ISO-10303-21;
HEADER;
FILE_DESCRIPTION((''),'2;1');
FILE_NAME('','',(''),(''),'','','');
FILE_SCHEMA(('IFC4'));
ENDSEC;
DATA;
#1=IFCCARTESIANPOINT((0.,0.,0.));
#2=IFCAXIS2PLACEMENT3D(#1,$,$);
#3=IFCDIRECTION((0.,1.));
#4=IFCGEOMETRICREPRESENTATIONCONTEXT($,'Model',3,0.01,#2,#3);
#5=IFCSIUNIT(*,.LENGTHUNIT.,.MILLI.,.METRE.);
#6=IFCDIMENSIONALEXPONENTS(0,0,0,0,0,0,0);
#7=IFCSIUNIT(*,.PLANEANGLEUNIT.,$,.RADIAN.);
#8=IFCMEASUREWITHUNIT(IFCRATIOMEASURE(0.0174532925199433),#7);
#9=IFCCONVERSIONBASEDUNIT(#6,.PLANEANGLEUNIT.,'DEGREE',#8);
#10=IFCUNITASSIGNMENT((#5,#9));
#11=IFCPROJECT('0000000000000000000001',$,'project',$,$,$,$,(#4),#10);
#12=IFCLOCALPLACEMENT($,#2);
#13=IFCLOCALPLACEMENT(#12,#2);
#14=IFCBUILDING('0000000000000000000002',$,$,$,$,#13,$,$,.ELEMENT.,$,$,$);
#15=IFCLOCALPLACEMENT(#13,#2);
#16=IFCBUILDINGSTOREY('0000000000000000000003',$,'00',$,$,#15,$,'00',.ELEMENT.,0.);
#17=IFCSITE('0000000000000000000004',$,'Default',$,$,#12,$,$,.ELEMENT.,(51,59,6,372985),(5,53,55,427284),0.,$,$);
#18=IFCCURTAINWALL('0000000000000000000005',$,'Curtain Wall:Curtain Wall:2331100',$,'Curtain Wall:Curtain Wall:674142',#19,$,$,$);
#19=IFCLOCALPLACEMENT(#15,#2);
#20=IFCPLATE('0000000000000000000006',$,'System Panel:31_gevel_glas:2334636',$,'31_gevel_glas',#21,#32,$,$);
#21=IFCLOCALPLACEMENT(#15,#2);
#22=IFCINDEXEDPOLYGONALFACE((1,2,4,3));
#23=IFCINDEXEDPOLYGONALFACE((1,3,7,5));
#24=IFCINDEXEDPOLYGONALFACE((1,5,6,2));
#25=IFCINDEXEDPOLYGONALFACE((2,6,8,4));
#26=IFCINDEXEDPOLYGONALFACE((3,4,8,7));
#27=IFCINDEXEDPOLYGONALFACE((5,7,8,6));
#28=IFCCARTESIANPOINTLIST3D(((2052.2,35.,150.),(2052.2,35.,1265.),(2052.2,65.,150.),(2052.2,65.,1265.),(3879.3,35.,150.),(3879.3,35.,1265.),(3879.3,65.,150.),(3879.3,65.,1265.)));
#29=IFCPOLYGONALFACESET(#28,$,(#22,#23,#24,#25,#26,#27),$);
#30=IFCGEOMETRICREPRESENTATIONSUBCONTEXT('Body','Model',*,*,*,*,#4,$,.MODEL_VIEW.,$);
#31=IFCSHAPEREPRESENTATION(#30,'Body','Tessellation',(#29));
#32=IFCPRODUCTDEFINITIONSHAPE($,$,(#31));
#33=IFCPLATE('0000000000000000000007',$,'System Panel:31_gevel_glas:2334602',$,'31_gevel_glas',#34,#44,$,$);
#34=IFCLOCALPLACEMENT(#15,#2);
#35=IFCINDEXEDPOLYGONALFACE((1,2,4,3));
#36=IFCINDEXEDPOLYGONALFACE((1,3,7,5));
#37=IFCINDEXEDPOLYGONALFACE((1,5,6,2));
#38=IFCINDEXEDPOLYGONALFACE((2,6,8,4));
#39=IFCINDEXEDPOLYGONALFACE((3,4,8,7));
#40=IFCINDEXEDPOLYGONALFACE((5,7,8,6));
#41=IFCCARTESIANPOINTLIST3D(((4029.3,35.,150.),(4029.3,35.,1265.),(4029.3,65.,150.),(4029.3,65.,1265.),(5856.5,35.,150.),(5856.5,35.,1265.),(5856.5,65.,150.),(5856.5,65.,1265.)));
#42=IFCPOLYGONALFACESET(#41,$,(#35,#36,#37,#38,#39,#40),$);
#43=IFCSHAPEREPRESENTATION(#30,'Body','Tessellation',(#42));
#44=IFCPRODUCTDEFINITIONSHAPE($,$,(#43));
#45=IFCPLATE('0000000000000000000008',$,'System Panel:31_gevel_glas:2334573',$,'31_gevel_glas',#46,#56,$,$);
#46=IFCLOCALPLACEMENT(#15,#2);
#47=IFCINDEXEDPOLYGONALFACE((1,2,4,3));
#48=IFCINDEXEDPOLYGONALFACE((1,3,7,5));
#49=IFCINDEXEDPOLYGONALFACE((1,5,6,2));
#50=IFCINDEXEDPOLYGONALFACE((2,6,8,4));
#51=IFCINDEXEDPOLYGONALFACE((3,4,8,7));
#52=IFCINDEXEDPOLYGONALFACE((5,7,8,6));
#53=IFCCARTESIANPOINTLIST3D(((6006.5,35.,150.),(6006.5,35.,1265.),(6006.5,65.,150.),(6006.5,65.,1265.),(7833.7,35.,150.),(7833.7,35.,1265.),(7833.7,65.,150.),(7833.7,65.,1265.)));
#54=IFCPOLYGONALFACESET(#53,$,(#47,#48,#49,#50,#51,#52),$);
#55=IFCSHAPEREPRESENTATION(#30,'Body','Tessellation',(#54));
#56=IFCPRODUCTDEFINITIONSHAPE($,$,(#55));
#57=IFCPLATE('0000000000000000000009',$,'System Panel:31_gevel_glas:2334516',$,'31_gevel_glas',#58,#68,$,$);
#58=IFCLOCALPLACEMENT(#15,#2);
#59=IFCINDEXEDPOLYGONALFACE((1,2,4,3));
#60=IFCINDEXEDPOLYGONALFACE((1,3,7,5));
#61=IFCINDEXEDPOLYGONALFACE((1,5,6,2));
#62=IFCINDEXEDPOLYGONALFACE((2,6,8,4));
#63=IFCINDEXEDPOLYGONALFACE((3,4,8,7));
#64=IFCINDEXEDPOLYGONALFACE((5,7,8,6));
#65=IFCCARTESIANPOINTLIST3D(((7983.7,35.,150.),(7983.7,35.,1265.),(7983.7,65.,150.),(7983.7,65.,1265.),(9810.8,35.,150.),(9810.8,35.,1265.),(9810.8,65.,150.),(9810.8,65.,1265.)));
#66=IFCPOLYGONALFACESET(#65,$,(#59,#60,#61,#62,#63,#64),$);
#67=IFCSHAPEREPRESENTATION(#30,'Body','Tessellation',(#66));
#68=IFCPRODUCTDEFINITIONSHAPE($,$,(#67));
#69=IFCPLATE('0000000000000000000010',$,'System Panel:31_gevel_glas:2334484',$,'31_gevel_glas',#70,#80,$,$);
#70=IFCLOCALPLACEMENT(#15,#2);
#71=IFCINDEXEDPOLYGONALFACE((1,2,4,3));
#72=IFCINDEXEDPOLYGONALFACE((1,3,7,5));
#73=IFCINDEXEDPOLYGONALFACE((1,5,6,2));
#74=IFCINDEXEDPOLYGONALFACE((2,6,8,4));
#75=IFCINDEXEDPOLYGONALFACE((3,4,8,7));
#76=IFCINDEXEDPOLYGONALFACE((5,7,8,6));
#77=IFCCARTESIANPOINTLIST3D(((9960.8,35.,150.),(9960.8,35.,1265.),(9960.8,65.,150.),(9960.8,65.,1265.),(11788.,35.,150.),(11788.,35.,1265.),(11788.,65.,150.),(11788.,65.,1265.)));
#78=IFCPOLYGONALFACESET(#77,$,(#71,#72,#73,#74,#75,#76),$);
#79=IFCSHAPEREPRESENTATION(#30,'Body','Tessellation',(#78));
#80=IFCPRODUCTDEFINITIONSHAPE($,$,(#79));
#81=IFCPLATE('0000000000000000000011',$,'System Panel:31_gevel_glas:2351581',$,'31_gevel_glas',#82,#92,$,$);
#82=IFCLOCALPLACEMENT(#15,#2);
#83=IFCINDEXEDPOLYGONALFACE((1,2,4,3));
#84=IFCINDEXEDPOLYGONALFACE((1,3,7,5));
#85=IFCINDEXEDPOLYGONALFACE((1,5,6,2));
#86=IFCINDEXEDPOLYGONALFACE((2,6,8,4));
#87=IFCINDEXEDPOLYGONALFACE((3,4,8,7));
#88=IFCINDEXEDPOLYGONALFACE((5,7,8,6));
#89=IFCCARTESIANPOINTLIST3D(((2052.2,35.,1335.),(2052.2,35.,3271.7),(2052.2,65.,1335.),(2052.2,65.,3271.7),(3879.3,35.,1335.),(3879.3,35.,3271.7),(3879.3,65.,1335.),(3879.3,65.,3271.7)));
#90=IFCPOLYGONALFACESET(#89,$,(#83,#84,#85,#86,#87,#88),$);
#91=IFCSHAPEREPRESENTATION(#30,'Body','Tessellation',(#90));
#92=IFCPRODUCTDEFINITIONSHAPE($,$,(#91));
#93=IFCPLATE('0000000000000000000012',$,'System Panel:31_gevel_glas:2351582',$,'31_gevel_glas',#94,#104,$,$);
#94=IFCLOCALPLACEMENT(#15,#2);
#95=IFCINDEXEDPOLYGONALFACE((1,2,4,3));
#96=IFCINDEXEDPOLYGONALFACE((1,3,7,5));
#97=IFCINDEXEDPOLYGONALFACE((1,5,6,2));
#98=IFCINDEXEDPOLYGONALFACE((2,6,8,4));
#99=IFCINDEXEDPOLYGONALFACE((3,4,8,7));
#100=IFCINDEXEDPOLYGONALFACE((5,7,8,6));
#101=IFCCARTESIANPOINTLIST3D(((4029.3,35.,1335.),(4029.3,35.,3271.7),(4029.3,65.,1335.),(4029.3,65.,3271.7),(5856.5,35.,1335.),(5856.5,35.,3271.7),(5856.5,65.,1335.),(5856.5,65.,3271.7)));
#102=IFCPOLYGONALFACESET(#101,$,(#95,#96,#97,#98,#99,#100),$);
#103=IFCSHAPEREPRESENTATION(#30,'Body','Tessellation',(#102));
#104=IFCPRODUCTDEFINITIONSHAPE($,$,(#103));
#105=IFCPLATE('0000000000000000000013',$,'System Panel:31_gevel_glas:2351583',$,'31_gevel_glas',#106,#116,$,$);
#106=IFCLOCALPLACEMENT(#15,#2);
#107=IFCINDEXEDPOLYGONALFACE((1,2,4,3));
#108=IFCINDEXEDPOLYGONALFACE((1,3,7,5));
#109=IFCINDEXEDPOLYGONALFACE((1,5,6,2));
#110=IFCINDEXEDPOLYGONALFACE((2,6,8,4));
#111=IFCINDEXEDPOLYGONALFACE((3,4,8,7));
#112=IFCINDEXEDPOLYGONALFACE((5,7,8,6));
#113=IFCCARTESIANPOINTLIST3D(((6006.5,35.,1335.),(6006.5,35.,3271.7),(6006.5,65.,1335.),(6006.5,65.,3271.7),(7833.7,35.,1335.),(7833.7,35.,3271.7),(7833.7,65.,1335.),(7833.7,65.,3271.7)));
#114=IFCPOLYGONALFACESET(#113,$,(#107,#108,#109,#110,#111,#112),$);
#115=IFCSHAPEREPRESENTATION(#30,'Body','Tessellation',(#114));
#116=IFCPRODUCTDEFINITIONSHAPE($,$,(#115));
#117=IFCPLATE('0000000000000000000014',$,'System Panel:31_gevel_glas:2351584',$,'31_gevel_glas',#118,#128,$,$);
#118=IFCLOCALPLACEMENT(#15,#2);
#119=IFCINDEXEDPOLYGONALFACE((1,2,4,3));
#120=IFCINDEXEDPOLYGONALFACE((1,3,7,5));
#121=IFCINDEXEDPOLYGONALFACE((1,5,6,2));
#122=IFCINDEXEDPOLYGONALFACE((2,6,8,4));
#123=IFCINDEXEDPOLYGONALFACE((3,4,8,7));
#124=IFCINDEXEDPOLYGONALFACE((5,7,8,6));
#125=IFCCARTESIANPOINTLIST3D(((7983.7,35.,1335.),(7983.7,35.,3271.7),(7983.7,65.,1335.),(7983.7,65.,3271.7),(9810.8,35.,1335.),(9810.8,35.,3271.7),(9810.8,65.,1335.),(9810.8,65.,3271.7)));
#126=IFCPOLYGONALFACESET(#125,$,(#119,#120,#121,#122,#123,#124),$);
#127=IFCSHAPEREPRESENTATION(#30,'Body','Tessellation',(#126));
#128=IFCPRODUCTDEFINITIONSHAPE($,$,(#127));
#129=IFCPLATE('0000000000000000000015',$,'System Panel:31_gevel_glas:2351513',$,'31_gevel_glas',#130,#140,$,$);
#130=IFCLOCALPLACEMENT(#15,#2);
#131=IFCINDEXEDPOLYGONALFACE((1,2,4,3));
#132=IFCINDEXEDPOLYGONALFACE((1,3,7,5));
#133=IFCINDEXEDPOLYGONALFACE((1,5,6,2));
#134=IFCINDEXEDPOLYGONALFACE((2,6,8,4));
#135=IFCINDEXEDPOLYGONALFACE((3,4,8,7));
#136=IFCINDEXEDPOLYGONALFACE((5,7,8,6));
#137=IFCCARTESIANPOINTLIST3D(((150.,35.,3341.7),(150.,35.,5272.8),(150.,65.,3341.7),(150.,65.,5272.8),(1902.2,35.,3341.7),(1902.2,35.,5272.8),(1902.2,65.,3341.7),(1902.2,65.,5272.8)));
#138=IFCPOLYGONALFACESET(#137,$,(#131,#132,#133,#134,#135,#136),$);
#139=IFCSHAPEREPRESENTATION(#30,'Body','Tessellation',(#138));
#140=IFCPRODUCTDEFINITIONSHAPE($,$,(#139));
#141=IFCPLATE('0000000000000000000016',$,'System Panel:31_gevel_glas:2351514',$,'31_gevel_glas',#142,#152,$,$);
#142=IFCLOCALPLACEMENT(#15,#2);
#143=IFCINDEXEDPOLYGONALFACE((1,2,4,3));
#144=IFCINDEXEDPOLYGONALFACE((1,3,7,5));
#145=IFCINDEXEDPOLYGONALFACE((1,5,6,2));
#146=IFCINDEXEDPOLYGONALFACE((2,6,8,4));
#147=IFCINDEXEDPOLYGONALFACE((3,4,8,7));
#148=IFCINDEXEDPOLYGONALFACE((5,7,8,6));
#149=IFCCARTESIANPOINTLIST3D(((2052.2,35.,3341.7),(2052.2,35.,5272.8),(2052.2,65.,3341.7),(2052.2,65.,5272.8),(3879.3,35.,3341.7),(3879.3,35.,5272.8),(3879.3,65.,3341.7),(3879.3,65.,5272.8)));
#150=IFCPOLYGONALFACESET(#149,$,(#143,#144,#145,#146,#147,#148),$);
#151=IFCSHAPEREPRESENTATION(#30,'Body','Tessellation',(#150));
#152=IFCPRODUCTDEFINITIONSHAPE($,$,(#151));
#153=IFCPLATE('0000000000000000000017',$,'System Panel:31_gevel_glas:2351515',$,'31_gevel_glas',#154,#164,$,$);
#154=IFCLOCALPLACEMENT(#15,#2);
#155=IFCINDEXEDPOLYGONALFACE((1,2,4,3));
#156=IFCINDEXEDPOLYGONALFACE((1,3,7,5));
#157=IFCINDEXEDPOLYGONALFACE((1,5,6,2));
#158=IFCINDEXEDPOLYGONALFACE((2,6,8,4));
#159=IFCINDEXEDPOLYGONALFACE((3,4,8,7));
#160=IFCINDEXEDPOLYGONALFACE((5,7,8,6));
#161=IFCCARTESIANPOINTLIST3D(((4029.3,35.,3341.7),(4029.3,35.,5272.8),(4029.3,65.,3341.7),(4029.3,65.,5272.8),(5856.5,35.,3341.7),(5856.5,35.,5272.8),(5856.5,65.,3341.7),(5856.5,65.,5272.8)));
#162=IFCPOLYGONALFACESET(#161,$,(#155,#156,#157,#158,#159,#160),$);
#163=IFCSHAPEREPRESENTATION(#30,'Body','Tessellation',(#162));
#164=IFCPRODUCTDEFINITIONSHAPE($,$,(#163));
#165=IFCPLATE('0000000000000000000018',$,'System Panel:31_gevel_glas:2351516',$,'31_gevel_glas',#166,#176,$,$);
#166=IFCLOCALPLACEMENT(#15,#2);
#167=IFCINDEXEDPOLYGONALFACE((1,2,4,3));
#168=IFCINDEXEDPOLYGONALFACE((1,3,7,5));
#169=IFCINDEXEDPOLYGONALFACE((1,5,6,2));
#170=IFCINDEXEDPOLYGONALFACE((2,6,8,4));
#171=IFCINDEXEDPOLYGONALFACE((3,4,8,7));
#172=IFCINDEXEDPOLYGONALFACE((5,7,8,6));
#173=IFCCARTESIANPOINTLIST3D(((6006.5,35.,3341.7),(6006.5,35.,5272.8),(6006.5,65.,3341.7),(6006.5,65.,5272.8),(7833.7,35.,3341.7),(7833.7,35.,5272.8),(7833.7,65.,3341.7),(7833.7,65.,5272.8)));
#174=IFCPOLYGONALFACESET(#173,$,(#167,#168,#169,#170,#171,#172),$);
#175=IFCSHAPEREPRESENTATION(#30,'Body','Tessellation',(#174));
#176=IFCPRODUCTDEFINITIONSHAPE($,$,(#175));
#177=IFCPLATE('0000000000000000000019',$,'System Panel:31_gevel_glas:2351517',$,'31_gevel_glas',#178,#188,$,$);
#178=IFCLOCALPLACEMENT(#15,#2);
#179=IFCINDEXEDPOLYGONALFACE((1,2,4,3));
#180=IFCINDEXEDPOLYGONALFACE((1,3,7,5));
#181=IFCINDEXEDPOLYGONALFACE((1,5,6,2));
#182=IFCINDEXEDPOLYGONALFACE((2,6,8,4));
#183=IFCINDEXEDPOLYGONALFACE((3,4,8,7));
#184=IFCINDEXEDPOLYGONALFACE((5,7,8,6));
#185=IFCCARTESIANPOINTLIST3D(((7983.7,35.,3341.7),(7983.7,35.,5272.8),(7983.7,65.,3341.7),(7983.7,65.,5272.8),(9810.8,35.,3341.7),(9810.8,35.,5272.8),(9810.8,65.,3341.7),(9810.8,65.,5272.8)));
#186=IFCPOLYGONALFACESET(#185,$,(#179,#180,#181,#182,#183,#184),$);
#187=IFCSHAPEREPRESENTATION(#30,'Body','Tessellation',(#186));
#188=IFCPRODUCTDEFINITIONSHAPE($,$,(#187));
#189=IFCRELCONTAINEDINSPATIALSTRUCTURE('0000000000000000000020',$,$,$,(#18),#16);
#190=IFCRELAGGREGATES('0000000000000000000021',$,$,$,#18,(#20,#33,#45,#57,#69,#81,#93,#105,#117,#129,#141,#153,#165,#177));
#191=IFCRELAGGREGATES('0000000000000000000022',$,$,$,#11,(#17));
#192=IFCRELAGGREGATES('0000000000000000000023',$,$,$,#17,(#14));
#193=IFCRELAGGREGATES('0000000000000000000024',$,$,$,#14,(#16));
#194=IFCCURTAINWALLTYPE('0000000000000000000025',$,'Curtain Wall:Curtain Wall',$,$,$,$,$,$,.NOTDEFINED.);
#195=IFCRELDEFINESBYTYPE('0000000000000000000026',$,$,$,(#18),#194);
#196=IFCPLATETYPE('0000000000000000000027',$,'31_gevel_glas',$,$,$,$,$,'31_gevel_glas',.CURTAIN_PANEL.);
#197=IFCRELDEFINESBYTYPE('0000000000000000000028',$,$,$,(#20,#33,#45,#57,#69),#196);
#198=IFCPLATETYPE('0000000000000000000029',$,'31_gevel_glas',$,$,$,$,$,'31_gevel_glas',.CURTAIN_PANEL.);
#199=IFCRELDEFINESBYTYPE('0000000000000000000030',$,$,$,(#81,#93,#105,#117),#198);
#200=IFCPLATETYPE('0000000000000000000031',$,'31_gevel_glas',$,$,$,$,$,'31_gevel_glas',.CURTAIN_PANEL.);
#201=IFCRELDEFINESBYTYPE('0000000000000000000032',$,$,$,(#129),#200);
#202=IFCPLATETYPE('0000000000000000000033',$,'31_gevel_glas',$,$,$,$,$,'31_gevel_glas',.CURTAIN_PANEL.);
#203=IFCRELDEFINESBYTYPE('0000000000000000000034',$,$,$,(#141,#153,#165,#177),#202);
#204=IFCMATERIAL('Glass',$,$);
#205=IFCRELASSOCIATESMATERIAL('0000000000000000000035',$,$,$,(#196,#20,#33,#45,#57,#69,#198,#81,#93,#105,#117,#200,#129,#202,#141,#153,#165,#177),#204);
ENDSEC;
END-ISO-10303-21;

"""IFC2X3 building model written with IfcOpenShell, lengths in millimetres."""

from ifc_helpers import new_model, entity, si_unit, converted_unit, direction, frame, origin, origin_2d_with_axis, place, context, subcontext, project, spatial, rectangle, extrude, source, transform, mapped, material, type_object, type_shapes, element, aggregate, save


model = new_model("IFC2X3")

# Units and contexts
model_context = context("Model", 3, precision=0.01, world=origin(), true_north=direction((0.0, 1.0)))
body_context = subcontext(model_context, "Body", "Model", "MODEL_VIEW")
ifc_project = project(units=[si_unit("LENGTHUNIT", "METRE", prefix="MILLI"), converted_unit("PLANEANGLEUNIT", "DEGREE", entity("IfcRatioMeasure", 0.0174532925199433), si_unit("PLANEANGLEUNIT", "RADIAN"), dimensions=[0, 0, 0, 0, 0, 0, 0])], contexts=[model_context])

# Site, building, storey
site_placement = place(None, origin())
site = spatial("IfcSite", under=ifc_project, at=site_placement, Name="Default", CompositionType="ELEMENT", RefLatitude=(51, 59, 6, 372985), RefLongitude=(5, 53, 55, 427284), RefElevation=0.0)
building_placement = place(site_placement, origin())
building = spatial("IfcBuilding", under=site, at=building_placement, CompositionType="ELEMENT")
storey_placement = place(building_placement, origin())
storey = spatial("IfcBuildingStorey", under=building, at=storey_placement, Name="00", LongName="00", CompositionType="ELEMENT", Elevation=0.0)

# Curtain wall, plates
curtain_wall_type = type_object("IfcCurtainWallType", Name="Curtain Wall:Curtain Wall", PredefinedType="NOTDEFINED")
curtain_wall_placement = place(storey_placement, origin())
curtain_wall = element("IfcCurtainWall", 1, at=curtain_wall_placement, inside=storey, type_object=curtain_wall_type, Name="Curtain Wall:Curtain Wall:2331100", ObjectType="Curtain Wall:Curtain Wall:674142")
ifc_material = material(Name="Glass")
plate_type_1 = type_object("IfcPlateType", Name="31_gevel_glas", ElementType="31_gevel_glas", PredefinedType="CURTAIN_PANEL", material=ifc_material)
shared_shape_1 = source(origin(), body_context, "Body", "SweptSolid", [
    extrude(rectangle(XDim=30.0, YDim=1827.2, at=origin_2d_with_axis()), frame((0.0, 50.0, 0.0), z_axis=(0.0, 0.0, 1.0), x_axis=(0.0, 1.0, 0.0)), (0.0, 0.0, 1.0), 1115.0),
])
type_shapes(plate_type_1, [shared_shape_1])
plate_1_placement = place(curtain_wall_placement, frame((2965.7, 0.0, 150.0)))
plate_1 = element("IfcPlate", 2, at=plate_1_placement, type_object=plate_type_1, material=ifc_material, Name="System Panel:31_gevel_glas:2334636", ObjectType="31_gevel_glas", context=body_context, shape_type="MappedRepresentation", body=[
    mapped(shared_shape_1, transform((0.0, 0.0, 0.0), scale=1.0)),
])
plate_2_placement = place(curtain_wall_placement, frame((4942.9, 0.0, 150.0)))
plate_2 = element("IfcPlate", 3, at=plate_2_placement, type_object=plate_type_1, material=ifc_material, Name="System Panel:31_gevel_glas:2334602", ObjectType="31_gevel_glas", context=body_context, shape_type="MappedRepresentation", body=[
    mapped(shared_shape_1, transform((0.0, 0.0, 0.0), scale=1.0)),
])
plate_3_placement = place(curtain_wall_placement, frame((6920.1, 0.0, 150.0)))
plate_3 = element("IfcPlate", 4, at=plate_3_placement, type_object=plate_type_1, material=ifc_material, Name="System Panel:31_gevel_glas:2334573", ObjectType="31_gevel_glas", context=body_context, shape_type="MappedRepresentation", body=[
    mapped(shared_shape_1, transform((0.0, 0.0, 0.0), scale=1.0)),
])
plate_4_placement = place(curtain_wall_placement, frame((8897.2, 0.0, 150.0)))
plate_4 = element("IfcPlate", 5, at=plate_4_placement, type_object=plate_type_1, material=ifc_material, Name="System Panel:31_gevel_glas:2334516", ObjectType="31_gevel_glas", context=body_context, shape_type="MappedRepresentation", body=[
    mapped(shared_shape_1, transform((0.0, 0.0, 0.0), scale=1.0)),
])
plate_5_placement = place(curtain_wall_placement, frame((10874.4, 0.0, 150.0)))
plate_5 = element("IfcPlate", 6, at=plate_5_placement, type_object=plate_type_1, material=ifc_material, Name="System Panel:31_gevel_glas:2334484", ObjectType="31_gevel_glas", context=body_context, shape_type="MappedRepresentation", body=[
    mapped(shared_shape_1, transform((0.0, 0.0, 0.0), scale=1.0)),
])
plate_type_2 = type_object("IfcPlateType", Name="31_gevel_glas", ElementType="31_gevel_glas", PredefinedType="CURTAIN_PANEL", material=ifc_material)
shared_shape_2 = source(origin(), body_context, "Body", "SweptSolid", [
    extrude(rectangle(XDim=30.0, YDim=1827.2, at=origin_2d_with_axis()), frame((0.0, 50.0, 0.0), z_axis=(0.0, 0.0, 1.0), x_axis=(0.0, 1.0, 0.0)), (0.0, 0.0, 1.0), 1936.7),
])
type_shapes(plate_type_2, [shared_shape_2])
plate_6_placement = place(curtain_wall_placement, frame((2965.7, 0.0, 1335.0)))
plate_6 = element("IfcPlate", 7, at=plate_6_placement, type_object=plate_type_2, material=ifc_material, Name="System Panel:31_gevel_glas:2351581", ObjectType="31_gevel_glas", context=body_context, shape_type="MappedRepresentation", body=[
    mapped(shared_shape_2, transform((0.0, 0.0, 0.0), scale=1.0)),
])
plate_7_placement = place(curtain_wall_placement, frame((4942.9, 0.0, 1335.0)))
plate_7 = element("IfcPlate", 8, at=plate_7_placement, type_object=plate_type_2, material=ifc_material, Name="System Panel:31_gevel_glas:2351582", ObjectType="31_gevel_glas", context=body_context, shape_type="MappedRepresentation", body=[
    mapped(shared_shape_2, transform((0.0, 0.0, 0.0), scale=1.0)),
])
plate_8_placement = place(curtain_wall_placement, frame((6920.1, 0.0, 1335.0)))
plate_8 = element("IfcPlate", 9, at=plate_8_placement, type_object=plate_type_2, material=ifc_material, Name="System Panel:31_gevel_glas:2351583", ObjectType="31_gevel_glas", context=body_context, shape_type="MappedRepresentation", body=[
    mapped(shared_shape_2, transform((0.0, 0.0, 0.0), scale=1.0)),
])
plate_9_placement = place(curtain_wall_placement, frame((8897.2, 0.0, 1335.0)))
plate_9 = element("IfcPlate", 10, at=plate_9_placement, type_object=plate_type_2, material=ifc_material, Name="System Panel:31_gevel_glas:2351584", ObjectType="31_gevel_glas", context=body_context, shape_type="MappedRepresentation", body=[
    mapped(shared_shape_2, transform((0.0, 0.0, 0.0), scale=1.0)),
])
plate_type_3 = type_object("IfcPlateType", Name="31_gevel_glas", ElementType="31_gevel_glas", PredefinedType="CURTAIN_PANEL", material=ifc_material)
shared_shape_3 = source(origin(), body_context, "Body", "SweptSolid", [
    extrude(rectangle(XDim=30.0, YDim=1752.2, at=origin_2d_with_axis()), frame((0.0, 50.0, 0.0), z_axis=(0.0, 0.0, 1.0), x_axis=(0.0, 1.0, 0.0)), (0.0, 0.0, 1.0), 1931.1),
])
type_shapes(plate_type_3, [shared_shape_3])
plate_10_placement = place(curtain_wall_placement, frame((1026.1, 0.0, 3341.7)))
plate_10 = element("IfcPlate", 11, at=plate_10_placement, type_object=plate_type_3, material=ifc_material, Name="System Panel:31_gevel_glas:2351513", ObjectType="31_gevel_glas", context=body_context, shape_type="MappedRepresentation", body=[
    mapped(shared_shape_3, transform((0.0, 0.0, 0.0), scale=1.0)),
])
plate_type_4 = type_object("IfcPlateType", Name="31_gevel_glas", ElementType="31_gevel_glas", PredefinedType="CURTAIN_PANEL", material=ifc_material)
shared_shape_4 = source(origin(), body_context, "Body", "SweptSolid", [
    extrude(rectangle(XDim=30.0, YDim=1827.2, at=origin_2d_with_axis()), frame((0.0, 50.0, 0.0), z_axis=(0.0, 0.0, 1.0), x_axis=(0.0, 1.0, 0.0)), (0.0, 0.0, 1.0), 1931.1),
])
type_shapes(plate_type_4, [shared_shape_4])
plate_11_placement = place(curtain_wall_placement, frame((2965.7, 0.0, 3341.7)))
plate_11 = element("IfcPlate", 12, at=plate_11_placement, type_object=plate_type_4, material=ifc_material, Name="System Panel:31_gevel_glas:2351514", ObjectType="31_gevel_glas", context=body_context, shape_type="MappedRepresentation", body=[
    mapped(shared_shape_4, transform((0.0, 0.0, 0.0), scale=1.0)),
])
plate_12_placement = place(curtain_wall_placement, frame((4942.9, 0.0, 3341.7)))
plate_12 = element("IfcPlate", 13, at=plate_12_placement, type_object=plate_type_4, material=ifc_material, Name="System Panel:31_gevel_glas:2351515", ObjectType="31_gevel_glas", context=body_context, shape_type="MappedRepresentation", body=[
    mapped(shared_shape_4, transform((0.0, 0.0, 0.0), scale=1.0)),
])
plate_13_placement = place(curtain_wall_placement, frame((6920.1, 0.0, 3341.7)))
plate_13 = element("IfcPlate", 14, at=plate_13_placement, type_object=plate_type_4, material=ifc_material, Name="System Panel:31_gevel_glas:2351516", ObjectType="31_gevel_glas", context=body_context, shape_type="MappedRepresentation", body=[
    mapped(shared_shape_4, transform((0.0, 0.0, 0.0), scale=1.0)),
])
plate_14_placement = place(curtain_wall_placement, frame((8897.2, 0.0, 3341.7)))
plate_14 = element("IfcPlate", 15, at=plate_14_placement, type_object=plate_type_4, material=ifc_material, Name="System Panel:31_gevel_glas:2351517", ObjectType="31_gevel_glas", context=body_context, shape_type="MappedRepresentation", body=[
    mapped(shared_shape_4, transform((0.0, 0.0, 0.0), scale=1.0)),
])
aggregate(curtain_wall, [plate_1, plate_2, plate_3, plate_4, plate_5, plate_6, plate_7, plate_8, plate_9, plate_10, plate_11, plate_12, plate_13, plate_14])

save(model, "model.ifc")
